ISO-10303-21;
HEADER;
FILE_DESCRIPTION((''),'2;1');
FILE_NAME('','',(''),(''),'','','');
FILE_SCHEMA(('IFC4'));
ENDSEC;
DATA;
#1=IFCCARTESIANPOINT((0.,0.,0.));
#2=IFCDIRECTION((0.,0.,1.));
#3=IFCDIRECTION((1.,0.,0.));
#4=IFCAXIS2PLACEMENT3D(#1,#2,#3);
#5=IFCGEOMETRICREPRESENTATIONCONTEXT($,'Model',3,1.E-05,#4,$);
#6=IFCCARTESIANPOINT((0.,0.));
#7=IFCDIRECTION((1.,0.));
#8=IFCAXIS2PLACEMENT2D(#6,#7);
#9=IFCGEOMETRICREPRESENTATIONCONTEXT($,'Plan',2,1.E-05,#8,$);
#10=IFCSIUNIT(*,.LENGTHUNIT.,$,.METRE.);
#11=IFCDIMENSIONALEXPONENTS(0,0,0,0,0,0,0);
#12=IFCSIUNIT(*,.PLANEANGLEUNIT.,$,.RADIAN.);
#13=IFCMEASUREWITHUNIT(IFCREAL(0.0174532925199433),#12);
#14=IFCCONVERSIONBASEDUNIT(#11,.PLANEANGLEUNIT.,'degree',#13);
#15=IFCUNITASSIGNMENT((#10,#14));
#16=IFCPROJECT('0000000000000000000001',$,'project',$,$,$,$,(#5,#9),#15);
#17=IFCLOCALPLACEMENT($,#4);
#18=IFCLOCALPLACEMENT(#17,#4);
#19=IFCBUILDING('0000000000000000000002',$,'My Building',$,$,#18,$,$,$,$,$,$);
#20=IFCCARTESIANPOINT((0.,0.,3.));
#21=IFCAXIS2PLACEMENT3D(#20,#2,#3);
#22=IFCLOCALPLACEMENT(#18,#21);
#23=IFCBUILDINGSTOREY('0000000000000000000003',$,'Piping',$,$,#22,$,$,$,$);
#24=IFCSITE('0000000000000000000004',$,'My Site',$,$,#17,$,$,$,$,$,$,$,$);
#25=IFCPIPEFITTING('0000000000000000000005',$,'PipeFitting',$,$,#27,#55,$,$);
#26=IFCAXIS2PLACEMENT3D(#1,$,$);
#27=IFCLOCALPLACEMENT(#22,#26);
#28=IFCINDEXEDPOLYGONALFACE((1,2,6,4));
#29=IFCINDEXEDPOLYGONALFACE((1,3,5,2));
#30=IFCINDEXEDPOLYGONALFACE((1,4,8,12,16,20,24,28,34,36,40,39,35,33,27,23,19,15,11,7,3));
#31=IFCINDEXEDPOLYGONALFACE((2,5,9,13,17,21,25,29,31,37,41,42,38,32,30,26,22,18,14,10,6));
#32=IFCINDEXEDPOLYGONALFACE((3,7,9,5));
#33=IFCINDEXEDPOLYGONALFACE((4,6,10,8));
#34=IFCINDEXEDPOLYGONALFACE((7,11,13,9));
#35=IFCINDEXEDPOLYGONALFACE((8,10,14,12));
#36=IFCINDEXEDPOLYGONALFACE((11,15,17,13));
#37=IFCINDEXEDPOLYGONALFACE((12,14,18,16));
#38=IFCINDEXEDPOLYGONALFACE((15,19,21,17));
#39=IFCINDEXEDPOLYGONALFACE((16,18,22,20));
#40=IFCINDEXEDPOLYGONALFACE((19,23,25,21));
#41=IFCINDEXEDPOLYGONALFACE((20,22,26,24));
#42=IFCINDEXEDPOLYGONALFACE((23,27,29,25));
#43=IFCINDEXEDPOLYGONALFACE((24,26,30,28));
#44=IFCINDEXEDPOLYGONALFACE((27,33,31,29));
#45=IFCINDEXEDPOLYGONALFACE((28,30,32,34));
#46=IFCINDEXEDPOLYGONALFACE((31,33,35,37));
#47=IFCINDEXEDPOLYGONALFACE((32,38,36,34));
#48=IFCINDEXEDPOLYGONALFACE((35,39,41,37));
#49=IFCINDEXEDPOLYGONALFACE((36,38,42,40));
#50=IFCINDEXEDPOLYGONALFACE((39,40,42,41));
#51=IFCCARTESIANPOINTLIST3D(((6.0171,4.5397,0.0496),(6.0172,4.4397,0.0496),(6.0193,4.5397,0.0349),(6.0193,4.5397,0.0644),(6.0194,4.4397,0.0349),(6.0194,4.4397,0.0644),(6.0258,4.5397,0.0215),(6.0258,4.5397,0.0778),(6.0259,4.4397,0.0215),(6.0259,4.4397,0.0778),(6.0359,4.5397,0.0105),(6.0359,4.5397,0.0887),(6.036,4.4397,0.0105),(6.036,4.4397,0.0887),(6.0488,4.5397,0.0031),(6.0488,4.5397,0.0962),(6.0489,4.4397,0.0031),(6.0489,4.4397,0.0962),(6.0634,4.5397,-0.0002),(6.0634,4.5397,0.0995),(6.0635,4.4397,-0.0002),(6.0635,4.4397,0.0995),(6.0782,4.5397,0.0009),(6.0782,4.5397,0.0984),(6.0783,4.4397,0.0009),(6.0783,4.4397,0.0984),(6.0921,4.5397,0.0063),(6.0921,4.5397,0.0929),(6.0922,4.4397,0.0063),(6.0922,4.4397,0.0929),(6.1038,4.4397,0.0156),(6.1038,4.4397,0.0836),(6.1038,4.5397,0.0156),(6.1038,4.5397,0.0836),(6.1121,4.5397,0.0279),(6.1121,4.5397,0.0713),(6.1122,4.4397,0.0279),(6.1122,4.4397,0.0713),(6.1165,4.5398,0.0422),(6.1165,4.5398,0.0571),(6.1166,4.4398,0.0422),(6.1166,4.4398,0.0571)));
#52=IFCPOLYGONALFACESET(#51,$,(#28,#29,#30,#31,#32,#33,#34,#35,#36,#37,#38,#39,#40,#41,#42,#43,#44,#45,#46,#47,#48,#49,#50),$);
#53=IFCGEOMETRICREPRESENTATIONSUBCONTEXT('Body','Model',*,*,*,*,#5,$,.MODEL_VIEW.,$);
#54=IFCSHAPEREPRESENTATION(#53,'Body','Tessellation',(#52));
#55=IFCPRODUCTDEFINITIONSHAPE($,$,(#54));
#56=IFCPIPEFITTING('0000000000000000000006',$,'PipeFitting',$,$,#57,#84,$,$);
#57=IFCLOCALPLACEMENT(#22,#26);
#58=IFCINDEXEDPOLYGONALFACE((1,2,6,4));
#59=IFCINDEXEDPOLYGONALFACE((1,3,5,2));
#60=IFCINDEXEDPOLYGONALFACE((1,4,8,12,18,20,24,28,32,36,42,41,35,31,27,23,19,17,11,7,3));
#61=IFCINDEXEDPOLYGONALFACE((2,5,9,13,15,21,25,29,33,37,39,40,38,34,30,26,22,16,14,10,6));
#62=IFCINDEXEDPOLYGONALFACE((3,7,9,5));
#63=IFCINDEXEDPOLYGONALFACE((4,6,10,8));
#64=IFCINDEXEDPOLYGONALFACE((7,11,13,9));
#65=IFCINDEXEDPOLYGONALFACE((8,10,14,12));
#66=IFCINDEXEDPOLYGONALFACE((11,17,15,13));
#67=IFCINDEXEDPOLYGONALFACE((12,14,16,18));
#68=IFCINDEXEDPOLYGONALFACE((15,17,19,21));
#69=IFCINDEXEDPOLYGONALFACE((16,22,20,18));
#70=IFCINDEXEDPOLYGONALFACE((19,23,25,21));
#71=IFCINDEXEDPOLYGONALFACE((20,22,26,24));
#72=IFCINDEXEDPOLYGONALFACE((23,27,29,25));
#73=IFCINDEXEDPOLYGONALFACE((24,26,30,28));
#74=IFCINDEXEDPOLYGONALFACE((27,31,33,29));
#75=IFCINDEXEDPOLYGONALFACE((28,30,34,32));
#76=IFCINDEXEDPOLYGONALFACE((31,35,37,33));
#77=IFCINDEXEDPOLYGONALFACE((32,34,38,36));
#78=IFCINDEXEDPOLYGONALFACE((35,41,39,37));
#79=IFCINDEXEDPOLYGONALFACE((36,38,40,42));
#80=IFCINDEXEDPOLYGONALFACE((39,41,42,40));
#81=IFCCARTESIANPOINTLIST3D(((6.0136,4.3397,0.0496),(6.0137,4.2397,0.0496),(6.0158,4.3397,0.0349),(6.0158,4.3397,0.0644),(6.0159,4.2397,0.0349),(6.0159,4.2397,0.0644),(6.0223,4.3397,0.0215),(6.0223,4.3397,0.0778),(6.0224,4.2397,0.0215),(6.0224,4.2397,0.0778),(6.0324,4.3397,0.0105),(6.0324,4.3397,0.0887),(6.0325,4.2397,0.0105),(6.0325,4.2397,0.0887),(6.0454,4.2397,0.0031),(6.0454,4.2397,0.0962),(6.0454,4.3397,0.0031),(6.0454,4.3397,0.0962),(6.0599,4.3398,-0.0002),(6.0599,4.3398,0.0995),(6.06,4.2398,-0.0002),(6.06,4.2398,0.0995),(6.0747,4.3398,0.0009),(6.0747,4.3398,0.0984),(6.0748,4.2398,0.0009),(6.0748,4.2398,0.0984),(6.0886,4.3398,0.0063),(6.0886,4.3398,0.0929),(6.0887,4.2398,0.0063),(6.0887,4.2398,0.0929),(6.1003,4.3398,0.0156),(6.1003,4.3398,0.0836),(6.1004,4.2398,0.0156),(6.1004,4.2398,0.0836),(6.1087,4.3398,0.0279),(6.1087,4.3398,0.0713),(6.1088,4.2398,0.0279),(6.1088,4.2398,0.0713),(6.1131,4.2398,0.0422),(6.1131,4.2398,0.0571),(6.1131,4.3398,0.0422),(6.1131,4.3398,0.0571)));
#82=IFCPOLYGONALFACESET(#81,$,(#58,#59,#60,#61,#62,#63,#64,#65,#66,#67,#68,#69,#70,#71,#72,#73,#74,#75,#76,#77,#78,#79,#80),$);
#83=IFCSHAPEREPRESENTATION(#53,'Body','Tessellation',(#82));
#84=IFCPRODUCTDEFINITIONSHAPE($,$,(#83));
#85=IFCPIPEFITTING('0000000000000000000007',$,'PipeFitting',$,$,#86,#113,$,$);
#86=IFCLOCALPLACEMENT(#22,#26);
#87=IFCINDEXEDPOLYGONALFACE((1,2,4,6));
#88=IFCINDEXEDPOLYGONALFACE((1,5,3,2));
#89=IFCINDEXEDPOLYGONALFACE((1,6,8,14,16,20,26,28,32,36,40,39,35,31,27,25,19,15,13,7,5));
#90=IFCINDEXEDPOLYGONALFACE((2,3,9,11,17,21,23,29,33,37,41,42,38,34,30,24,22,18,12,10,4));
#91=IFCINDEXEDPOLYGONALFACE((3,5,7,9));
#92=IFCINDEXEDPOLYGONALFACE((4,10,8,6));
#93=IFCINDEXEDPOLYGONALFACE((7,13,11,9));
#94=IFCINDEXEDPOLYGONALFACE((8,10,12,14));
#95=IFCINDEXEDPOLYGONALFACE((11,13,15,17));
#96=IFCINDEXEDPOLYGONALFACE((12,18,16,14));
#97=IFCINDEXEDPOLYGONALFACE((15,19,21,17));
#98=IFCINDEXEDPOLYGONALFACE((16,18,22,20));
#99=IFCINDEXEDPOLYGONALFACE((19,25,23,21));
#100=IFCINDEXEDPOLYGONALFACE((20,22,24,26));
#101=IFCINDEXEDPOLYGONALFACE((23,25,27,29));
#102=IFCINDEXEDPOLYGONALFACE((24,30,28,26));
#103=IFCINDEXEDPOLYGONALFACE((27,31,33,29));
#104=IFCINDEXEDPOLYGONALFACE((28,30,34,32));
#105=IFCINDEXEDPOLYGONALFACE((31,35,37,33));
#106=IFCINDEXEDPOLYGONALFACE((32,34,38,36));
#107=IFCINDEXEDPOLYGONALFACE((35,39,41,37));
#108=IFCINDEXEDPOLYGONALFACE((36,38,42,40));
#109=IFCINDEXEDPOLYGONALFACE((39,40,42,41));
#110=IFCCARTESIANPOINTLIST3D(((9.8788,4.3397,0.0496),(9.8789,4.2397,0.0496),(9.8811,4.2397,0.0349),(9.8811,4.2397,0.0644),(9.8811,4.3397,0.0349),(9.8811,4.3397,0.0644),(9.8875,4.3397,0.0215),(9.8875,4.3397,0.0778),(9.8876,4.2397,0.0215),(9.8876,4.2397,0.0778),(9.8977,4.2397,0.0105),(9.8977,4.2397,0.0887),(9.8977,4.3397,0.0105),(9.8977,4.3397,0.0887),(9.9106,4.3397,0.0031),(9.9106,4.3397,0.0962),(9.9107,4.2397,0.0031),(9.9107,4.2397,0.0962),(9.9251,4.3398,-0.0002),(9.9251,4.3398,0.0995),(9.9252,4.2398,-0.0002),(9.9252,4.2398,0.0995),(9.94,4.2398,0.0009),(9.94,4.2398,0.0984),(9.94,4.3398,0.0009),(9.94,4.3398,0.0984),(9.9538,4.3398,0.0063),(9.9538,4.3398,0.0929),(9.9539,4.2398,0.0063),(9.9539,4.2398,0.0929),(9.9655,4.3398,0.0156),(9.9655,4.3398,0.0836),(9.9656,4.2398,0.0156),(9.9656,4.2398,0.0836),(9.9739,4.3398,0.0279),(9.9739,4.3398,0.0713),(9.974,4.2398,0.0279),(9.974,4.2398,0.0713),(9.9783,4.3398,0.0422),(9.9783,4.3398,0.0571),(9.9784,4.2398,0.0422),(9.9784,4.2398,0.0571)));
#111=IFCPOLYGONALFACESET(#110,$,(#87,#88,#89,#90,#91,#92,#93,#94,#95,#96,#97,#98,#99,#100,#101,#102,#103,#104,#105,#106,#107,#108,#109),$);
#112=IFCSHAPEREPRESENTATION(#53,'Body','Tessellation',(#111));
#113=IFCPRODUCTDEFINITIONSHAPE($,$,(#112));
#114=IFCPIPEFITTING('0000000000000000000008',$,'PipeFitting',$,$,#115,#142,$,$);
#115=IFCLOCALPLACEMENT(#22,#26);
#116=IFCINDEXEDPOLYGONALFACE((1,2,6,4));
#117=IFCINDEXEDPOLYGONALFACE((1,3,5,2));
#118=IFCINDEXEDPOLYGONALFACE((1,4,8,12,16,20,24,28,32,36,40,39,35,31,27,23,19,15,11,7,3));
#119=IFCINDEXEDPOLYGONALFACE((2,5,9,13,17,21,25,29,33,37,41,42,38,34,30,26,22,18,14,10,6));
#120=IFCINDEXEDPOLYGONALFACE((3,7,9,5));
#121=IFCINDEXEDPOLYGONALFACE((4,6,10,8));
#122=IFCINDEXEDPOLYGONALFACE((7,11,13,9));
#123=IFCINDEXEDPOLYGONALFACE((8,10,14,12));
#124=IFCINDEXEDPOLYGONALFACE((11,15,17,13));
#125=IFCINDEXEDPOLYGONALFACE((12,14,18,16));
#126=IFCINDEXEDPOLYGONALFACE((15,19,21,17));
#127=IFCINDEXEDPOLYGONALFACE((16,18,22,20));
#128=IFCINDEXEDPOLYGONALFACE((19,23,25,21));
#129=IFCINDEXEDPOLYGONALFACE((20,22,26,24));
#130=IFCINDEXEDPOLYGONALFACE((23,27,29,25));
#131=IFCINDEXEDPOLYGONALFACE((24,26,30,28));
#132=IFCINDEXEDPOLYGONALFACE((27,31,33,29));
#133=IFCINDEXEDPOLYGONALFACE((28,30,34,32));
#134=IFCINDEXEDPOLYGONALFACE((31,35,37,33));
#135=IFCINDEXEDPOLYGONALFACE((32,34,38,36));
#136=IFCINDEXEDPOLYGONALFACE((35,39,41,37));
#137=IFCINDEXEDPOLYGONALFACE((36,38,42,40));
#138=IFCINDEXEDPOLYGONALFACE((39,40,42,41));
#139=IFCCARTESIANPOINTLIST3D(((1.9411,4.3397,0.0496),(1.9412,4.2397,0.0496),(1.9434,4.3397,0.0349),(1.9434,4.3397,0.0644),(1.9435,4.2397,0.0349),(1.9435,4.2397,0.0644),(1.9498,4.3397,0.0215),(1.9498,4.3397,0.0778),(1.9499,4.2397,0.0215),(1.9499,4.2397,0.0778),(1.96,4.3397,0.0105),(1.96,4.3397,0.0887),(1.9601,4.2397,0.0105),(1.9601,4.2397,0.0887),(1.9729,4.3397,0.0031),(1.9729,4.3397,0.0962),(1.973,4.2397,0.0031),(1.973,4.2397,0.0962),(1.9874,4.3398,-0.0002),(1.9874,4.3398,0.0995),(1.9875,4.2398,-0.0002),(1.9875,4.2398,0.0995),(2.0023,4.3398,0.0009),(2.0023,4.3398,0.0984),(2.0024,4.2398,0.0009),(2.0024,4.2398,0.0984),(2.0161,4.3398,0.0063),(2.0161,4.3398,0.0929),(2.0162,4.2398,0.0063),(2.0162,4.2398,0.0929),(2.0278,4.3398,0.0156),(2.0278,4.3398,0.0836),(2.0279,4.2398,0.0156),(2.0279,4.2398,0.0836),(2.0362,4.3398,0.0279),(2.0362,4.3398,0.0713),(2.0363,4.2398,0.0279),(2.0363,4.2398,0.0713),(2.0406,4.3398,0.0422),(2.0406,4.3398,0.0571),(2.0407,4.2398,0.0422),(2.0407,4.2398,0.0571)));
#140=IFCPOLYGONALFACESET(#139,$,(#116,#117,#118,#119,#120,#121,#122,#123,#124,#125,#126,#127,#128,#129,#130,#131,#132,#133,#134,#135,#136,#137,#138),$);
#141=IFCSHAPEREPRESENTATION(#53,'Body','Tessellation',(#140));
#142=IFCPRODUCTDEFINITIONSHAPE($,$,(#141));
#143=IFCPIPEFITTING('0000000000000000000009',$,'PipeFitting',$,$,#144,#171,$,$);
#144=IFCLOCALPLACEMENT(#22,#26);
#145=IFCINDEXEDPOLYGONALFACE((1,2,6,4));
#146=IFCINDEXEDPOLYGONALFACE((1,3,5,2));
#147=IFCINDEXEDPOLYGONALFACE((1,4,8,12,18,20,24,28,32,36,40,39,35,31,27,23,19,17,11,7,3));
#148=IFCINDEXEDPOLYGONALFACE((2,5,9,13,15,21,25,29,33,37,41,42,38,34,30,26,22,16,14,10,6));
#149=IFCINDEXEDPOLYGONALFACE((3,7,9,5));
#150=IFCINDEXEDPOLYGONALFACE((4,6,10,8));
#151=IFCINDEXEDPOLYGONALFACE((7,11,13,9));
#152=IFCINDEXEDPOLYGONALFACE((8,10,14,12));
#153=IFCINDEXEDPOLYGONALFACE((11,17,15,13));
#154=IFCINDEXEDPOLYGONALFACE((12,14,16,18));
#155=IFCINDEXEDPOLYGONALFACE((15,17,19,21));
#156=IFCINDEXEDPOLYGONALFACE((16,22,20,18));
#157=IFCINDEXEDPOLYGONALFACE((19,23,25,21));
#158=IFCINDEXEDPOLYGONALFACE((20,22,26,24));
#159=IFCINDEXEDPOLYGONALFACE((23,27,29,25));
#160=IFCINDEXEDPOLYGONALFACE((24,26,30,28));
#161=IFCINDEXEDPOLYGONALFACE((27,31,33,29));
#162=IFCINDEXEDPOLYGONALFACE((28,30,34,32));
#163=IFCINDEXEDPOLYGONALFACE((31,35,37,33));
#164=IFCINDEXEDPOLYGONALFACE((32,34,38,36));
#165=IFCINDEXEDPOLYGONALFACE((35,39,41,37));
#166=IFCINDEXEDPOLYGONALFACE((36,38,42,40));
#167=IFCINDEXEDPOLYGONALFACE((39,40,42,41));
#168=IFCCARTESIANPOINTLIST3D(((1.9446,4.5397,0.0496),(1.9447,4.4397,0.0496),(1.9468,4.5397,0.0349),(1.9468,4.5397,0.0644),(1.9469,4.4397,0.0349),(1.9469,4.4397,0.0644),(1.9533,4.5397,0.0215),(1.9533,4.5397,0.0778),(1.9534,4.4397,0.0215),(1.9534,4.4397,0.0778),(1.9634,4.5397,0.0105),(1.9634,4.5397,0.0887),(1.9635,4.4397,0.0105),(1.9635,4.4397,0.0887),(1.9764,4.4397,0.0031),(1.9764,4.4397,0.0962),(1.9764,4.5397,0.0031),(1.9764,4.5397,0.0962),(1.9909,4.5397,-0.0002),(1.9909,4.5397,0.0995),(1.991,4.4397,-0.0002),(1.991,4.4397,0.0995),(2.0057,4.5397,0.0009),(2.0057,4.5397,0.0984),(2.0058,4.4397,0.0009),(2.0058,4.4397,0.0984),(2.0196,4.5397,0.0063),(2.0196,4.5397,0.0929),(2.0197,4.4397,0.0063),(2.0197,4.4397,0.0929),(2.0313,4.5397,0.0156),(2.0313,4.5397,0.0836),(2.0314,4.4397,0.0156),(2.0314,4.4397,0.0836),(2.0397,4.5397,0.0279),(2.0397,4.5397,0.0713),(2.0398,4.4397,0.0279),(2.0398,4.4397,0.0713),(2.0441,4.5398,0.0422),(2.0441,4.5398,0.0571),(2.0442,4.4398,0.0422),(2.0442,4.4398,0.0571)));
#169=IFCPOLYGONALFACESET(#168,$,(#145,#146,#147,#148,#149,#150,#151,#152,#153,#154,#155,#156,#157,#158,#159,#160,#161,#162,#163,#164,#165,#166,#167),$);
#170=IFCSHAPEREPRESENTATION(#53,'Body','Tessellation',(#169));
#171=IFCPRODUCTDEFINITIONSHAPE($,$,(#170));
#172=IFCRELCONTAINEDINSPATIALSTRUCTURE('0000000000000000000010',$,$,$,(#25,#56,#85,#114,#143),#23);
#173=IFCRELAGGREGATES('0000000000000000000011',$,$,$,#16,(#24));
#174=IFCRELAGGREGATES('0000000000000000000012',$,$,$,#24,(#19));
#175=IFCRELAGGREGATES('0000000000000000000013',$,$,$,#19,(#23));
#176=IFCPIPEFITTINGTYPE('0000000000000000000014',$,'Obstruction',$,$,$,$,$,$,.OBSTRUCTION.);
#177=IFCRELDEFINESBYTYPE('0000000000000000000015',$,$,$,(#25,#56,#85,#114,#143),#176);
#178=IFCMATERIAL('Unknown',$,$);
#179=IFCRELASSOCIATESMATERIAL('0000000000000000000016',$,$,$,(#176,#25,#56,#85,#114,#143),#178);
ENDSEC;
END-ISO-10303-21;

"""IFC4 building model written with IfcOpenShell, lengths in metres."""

from ifc_helpers import new_model, entity, si_unit, converted_unit, frame, origin_with_axes, origin_2d_with_axis, place, context, subcontext, project, spatial, circle, extrude, material, material_profile, profile_set, profile_usage, type_object, element, save


model = new_model("IFC4")

# Units and contexts
model_context = context("Model", 3, precision=1e-05, world=origin_with_axes())
plan_context = context("Plan", 2, precision=1e-05, world=origin_2d_with_axis())
body_context = subcontext(model_context, "Body", "Model", "MODEL_VIEW")
ifc_project = project(units=[si_unit("LENGTHUNIT", "METRE"), converted_unit("PLANEANGLEUNIT", "degree", entity("IfcReal", 0.0174532925199433), si_unit("PLANEANGLEUNIT", "RADIAN"), dimensions=[0, 0, 0, 0, 0, 0, 0])], contexts=[model_context, plan_context])

# Site, building, storey
site_placement = place(None, origin_with_axes())
site = spatial("IfcSite", under=ifc_project, at=site_placement, Name="My Site")
building_placement = place(site_placement, origin_with_axes())
building = spatial("IfcBuilding", under=site, at=building_placement, Name="My Building")
storey_placement = place(building_placement, frame((0.0, 0.0, 3.0), z_axis=(0.0, 0.0, 1.0), x_axis=(1.0, 0.0, 0.0)))
storey = spatial("IfcBuildingStorey", under=building, at=storey_placement, Name="Piping")

# Shared definitions
ifc_material = material(Name="Unknown")

# Pipe fittings
ifc_material_profile_1 = material_profile(ifc_material, circle(Radius=0.05))
ifc_profile_set_1 = profile_set([ifc_material_profile_1])
ifc_profile_usage_1 = profile_usage(ifc_profile_set_1, cardinal=16)
pipe_fitting_type_1 = type_object("IfcPipeFittingType", Name="Obstruction", PredefinedType="OBSTRUCTION", material=ifc_profile_set_1)
pipe_fitting_1_placement = place(storey_placement, frame((6.0672, 4.4397, 0.0496), z_axis=(-0.000872, 1.0, 0.000001), x_axis=(-1.0, -0.000872, 0.0)))
element("IfcPipeFitting", 1, at=pipe_fitting_1_placement, inside=storey, type_object=pipe_fitting_type_1, material=ifc_profile_usage_1, Name="PipeFitting", context=body_context, shape_type="SweptSolid", body=[
    extrude(circle(Radius=0.05), origin_with_axes(), (0.0, 0.0, 1.0), 0.1),
])
ifc_profile_usage_2 = profile_usage(ifc_profile_set_1, cardinal=16)
pipe_fitting_2_placement = place(storey_placement, frame((6.0637, 4.2398, 0.0496), z_axis=(-0.000873, 1.0, 0.000001), x_axis=(-1.0, -0.000873, 0.0)))
element("IfcPipeFitting", 2, at=pipe_fitting_2_placement, inside=storey, type_object=pipe_fitting_type_1, material=ifc_profile_usage_2, Name="PipeFitting", context=body_context, shape_type="SweptSolid", body=[
    extrude(circle(Radius=0.05), origin_with_axes(), (0.0, 0.0, 1.0), 0.1),
])
ifc_profile_usage_3 = profile_usage(ifc_profile_set_1, cardinal=16)
pipe_fitting_3_placement = place(storey_placement, frame((9.9289, 4.2398, 0.0496), z_axis=(-0.000873, 1.0, 0.000001), x_axis=(-1.0, -0.000873, 0.0)))
element("IfcPipeFitting", 3, at=pipe_fitting_3_placement, inside=storey, type_object=pipe_fitting_type_1, material=ifc_profile_usage_3, Name="PipeFitting", context=body_context, shape_type="SweptSolid", body=[
    extrude(circle(Radius=0.05), origin_with_axes(), (0.0, 0.0, 1.0), 0.1),
])
ifc_profile_usage_4 = profile_usage(ifc_profile_set_1, cardinal=16)
pipe_fitting_4_placement = place(storey_placement, frame((1.9912, 4.2398, 0.0496), z_axis=(-0.000873, 1.0, 0.000001), x_axis=(-1.0, -0.000873, 0.0)))
element("IfcPipeFitting", 4, at=pipe_fitting_4_placement, inside=storey, type_object=pipe_fitting_type_1, material=ifc_profile_usage_4, Name="PipeFitting", context=body_context, shape_type="SweptSolid", body=[
    extrude(circle(Radius=0.05), origin_with_axes(), (0.0, 0.0, 1.0), 0.1),
])
ifc_profile_usage_5 = profile_usage(ifc_profile_set_1, cardinal=16)
pipe_fitting_5_placement = place(storey_placement, frame((1.9947, 4.4397, 0.0496), z_axis=(-0.000872, 1.0, 0.000001), x_axis=(-1.0, -0.000872, 0.0)))
element("IfcPipeFitting", 5, at=pipe_fitting_5_placement, inside=storey, type_object=pipe_fitting_type_1, material=ifc_profile_usage_5, Name="PipeFitting", context=body_context, shape_type="SweptSolid", body=[
    extrude(circle(Radius=0.05), origin_with_axes(), (0.0, 0.0, 1.0), 0.1),
])

save(model, "model.ifc")
